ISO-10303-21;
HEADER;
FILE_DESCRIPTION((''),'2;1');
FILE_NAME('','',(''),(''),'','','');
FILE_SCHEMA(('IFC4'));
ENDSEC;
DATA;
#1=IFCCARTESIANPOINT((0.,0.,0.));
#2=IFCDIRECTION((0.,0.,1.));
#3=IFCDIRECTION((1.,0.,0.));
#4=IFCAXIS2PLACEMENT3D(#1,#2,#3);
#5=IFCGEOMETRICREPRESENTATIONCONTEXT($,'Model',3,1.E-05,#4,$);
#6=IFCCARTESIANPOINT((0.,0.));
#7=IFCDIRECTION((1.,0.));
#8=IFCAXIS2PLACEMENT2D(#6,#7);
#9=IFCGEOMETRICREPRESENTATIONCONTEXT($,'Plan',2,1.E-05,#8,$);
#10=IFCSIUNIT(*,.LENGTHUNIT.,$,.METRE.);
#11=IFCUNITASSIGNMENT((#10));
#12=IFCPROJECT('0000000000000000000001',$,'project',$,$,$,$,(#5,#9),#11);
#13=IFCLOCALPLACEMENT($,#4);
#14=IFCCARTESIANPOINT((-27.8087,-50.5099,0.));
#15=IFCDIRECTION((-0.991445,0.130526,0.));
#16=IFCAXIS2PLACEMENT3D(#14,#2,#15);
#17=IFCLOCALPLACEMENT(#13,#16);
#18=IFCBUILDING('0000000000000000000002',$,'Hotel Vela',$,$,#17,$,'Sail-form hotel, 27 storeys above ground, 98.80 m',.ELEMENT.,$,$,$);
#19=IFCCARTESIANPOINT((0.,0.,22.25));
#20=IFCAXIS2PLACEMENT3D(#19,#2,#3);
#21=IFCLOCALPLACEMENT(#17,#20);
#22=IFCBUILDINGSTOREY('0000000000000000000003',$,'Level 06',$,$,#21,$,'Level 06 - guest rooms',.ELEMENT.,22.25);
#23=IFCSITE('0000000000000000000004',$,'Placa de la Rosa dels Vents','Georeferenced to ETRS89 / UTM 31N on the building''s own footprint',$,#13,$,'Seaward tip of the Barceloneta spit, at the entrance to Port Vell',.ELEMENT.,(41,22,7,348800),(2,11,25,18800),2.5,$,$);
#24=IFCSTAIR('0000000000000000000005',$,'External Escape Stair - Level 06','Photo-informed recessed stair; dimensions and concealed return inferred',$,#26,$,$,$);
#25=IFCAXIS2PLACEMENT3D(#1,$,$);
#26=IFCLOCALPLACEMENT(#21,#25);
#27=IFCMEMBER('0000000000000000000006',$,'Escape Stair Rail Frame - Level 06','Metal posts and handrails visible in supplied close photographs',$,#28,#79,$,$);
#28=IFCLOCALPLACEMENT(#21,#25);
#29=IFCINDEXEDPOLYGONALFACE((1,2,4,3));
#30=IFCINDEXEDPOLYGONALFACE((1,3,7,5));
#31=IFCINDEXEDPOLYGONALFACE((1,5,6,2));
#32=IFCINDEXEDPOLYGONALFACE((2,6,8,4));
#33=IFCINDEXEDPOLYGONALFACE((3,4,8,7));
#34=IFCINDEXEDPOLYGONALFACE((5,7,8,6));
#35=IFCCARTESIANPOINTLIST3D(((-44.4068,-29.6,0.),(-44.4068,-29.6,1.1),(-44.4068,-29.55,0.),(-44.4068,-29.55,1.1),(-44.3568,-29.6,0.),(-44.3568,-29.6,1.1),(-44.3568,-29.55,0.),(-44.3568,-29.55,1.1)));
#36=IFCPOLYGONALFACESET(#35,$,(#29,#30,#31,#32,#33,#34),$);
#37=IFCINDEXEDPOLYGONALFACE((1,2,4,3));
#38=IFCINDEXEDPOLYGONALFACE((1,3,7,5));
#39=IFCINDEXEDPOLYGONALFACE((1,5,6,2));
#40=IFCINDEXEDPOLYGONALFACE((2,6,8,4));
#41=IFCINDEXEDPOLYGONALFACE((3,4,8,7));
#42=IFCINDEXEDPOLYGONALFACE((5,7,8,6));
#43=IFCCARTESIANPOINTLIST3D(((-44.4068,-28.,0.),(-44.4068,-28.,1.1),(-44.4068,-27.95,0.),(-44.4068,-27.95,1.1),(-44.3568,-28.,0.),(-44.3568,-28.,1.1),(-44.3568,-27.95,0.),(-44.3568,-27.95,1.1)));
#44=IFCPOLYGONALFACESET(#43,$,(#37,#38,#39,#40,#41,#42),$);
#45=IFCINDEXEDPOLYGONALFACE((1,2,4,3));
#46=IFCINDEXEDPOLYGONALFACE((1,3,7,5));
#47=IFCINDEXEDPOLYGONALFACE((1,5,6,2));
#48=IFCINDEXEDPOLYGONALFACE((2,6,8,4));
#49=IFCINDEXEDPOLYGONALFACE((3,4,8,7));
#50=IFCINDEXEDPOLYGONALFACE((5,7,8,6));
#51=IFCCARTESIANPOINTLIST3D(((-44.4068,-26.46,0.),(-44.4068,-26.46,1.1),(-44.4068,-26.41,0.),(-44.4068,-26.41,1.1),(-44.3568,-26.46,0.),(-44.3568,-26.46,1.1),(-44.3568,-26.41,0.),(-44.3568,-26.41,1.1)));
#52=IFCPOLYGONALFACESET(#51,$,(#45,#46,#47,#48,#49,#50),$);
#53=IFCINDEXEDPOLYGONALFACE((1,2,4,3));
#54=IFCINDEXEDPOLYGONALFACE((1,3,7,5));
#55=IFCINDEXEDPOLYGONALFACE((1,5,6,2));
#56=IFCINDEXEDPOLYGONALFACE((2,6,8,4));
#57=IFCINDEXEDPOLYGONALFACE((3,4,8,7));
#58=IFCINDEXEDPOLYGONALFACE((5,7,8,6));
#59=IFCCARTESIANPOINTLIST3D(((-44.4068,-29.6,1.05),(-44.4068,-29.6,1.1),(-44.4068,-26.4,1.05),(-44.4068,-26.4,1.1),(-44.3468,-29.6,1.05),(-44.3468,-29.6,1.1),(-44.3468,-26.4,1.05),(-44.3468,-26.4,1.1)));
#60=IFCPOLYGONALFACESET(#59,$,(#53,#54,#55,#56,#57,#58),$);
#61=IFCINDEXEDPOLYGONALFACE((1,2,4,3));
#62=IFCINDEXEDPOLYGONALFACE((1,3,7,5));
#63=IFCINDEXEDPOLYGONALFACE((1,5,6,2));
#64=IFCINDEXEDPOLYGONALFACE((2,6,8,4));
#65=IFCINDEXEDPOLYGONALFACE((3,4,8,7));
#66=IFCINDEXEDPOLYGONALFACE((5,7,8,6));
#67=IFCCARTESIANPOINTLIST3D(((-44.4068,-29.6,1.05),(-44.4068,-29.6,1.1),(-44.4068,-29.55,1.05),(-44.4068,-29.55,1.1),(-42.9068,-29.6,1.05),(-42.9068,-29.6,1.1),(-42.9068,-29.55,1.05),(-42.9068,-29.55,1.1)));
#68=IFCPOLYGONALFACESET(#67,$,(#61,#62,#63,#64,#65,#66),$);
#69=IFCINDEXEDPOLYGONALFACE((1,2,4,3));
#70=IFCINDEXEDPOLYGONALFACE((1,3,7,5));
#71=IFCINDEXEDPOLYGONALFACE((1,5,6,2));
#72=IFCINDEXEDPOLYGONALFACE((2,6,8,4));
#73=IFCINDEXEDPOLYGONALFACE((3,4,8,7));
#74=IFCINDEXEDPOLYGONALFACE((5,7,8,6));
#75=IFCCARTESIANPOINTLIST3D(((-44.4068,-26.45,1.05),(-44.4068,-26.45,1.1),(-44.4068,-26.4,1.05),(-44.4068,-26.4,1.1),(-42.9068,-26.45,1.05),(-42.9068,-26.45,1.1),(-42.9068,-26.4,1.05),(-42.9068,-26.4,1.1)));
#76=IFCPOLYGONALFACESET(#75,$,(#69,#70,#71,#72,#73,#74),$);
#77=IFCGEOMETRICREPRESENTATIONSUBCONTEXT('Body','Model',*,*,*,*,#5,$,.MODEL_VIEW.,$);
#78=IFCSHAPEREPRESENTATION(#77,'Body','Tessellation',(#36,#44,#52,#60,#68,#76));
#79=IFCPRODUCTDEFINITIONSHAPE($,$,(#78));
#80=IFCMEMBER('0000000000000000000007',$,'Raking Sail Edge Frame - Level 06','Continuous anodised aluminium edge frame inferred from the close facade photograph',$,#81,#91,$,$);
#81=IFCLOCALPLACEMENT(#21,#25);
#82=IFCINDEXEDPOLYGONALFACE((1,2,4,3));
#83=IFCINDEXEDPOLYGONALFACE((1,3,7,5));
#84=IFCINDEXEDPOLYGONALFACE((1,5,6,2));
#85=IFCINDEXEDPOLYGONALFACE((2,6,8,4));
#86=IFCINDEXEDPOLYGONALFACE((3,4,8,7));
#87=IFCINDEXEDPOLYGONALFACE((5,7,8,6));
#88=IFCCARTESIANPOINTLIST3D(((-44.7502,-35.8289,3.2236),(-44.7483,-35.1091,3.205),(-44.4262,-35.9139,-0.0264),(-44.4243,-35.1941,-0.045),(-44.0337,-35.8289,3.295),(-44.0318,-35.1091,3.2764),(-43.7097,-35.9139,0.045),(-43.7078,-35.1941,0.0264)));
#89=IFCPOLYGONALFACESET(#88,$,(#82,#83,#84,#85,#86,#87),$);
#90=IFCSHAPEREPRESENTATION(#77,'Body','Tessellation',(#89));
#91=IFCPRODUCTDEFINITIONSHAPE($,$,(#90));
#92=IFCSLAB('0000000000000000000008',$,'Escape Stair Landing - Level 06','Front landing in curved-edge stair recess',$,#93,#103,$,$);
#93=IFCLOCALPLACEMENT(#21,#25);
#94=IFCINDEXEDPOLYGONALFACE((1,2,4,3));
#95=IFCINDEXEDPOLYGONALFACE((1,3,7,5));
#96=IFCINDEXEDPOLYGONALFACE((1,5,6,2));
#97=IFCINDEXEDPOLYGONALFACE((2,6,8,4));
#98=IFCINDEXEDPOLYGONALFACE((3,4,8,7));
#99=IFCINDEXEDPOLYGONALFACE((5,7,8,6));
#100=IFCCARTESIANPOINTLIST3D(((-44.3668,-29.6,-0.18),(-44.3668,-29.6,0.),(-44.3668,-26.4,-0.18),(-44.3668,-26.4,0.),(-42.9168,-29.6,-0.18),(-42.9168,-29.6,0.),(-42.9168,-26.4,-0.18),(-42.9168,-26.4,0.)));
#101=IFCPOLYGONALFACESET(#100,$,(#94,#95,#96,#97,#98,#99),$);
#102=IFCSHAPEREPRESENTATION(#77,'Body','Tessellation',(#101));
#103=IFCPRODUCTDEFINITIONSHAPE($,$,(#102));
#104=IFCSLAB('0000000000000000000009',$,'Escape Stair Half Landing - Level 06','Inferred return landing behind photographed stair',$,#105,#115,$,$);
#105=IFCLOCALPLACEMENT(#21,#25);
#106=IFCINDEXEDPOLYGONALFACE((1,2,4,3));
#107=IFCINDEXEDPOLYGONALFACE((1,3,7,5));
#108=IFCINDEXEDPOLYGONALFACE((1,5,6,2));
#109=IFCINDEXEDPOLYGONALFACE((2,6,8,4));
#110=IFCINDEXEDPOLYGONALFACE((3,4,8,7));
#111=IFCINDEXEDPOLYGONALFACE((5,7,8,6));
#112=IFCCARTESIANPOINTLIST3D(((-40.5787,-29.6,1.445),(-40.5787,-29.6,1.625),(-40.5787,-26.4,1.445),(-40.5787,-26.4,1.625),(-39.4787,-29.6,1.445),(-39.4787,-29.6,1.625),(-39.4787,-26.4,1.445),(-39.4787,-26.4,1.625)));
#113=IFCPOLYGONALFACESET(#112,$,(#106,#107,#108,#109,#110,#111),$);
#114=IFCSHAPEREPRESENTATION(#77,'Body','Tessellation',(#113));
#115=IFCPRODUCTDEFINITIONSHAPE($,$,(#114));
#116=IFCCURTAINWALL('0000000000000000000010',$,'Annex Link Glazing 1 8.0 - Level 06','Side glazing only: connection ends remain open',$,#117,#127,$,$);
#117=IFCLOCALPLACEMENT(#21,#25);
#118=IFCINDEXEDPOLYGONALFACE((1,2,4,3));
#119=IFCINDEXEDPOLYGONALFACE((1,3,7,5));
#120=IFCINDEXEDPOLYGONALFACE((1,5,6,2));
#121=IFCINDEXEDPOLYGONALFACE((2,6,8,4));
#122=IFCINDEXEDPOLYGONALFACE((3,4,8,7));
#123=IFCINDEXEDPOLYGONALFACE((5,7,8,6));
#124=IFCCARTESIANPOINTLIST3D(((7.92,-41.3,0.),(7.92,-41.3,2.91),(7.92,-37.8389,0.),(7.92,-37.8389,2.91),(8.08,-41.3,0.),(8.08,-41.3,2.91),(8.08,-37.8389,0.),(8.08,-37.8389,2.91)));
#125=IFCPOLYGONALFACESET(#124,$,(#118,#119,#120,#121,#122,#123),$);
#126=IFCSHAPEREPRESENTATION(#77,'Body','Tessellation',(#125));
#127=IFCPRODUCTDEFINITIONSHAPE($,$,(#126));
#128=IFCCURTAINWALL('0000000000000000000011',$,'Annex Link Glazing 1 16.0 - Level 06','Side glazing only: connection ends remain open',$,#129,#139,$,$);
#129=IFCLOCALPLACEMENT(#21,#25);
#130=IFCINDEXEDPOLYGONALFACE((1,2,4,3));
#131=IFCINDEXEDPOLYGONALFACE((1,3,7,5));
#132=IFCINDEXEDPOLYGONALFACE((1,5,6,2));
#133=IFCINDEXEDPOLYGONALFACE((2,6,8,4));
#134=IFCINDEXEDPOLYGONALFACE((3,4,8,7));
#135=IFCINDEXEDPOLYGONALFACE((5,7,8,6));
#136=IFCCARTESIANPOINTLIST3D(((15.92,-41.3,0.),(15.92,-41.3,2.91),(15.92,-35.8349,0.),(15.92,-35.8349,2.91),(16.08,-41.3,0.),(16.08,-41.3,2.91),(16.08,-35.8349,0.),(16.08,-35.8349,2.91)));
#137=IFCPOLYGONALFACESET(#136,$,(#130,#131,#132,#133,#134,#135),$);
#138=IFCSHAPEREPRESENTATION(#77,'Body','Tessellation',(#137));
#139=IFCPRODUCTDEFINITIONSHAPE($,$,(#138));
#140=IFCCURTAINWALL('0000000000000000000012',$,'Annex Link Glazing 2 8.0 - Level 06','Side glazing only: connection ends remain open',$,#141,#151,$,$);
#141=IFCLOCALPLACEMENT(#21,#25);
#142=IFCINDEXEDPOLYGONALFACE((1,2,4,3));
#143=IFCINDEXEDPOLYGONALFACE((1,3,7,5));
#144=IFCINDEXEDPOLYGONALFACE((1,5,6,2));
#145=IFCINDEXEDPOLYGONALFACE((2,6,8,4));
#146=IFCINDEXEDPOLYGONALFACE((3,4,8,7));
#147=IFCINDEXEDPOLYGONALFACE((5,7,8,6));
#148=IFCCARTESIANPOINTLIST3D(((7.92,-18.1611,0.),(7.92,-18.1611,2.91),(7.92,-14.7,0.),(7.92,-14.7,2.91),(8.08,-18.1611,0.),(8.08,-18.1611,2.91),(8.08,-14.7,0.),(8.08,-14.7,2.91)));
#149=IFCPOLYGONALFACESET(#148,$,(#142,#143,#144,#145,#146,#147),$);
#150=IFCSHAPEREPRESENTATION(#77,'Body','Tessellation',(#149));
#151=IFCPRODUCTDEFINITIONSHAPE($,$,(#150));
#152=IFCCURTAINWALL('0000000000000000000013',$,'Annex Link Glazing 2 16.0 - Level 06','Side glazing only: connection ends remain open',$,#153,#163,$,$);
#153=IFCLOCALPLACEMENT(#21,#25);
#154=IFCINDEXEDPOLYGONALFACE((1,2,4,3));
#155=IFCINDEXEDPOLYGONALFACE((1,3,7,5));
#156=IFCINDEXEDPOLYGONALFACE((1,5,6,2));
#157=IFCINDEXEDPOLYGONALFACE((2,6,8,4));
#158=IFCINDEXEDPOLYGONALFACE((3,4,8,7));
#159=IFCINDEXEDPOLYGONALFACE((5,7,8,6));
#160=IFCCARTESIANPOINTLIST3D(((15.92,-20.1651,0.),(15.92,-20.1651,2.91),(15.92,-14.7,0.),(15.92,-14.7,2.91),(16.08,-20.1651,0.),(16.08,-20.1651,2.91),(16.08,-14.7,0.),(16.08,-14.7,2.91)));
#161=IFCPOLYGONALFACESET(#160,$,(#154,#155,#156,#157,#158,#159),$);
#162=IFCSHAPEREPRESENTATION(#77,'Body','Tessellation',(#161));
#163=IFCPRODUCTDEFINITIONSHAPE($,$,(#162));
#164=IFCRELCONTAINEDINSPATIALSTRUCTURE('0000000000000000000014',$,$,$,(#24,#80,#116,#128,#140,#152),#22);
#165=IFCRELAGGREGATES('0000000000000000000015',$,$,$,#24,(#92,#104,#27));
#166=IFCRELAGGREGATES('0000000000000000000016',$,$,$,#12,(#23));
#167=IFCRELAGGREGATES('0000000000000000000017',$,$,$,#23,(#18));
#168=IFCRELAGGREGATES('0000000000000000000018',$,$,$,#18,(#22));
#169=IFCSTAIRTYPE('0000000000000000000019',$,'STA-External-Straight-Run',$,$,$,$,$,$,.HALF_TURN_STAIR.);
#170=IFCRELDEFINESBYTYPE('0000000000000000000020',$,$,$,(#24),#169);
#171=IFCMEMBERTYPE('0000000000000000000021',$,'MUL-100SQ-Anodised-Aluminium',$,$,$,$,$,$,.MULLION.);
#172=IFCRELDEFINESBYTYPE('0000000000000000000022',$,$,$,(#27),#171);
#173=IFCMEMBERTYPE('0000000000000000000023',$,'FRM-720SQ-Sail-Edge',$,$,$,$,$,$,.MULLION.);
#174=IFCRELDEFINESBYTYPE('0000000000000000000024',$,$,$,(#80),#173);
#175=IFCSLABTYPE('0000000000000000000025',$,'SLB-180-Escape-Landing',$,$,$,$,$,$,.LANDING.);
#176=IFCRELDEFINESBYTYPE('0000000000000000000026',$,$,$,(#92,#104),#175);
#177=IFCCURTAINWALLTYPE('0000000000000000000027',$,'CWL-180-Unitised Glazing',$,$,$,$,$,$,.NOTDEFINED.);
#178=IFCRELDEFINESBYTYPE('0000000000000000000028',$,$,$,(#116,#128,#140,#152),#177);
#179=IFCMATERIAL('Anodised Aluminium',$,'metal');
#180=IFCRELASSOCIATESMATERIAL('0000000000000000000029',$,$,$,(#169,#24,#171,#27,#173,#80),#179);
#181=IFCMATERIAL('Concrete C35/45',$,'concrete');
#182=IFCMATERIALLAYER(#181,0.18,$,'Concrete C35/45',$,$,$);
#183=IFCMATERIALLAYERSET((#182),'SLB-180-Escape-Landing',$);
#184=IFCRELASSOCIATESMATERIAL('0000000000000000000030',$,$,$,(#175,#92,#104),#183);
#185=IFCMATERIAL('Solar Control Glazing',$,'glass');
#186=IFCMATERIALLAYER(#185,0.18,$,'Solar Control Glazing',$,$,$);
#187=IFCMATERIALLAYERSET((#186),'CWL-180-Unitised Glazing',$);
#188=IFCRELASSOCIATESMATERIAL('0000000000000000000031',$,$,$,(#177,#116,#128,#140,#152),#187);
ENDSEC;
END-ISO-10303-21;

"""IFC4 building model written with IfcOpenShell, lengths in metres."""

from ifc_helpers import new_model, si_unit, frame, origin_with_axes, origin_2d_with_axis, place, context, subcontext, project, spatial, line, indexed_curve, rectangle, outline, extrude, material, layer, layer_set, layer_usage, material_profile, profile_set, profile_usage, type_object, element, aggregate, save


model = new_model("IFC4")

# Units and contexts
model_context = context("Model", 3, precision=1e-05, world=origin_with_axes())
plan_context = context("Plan", 2, precision=1e-05, world=origin_2d_with_axis())
body_context = subcontext(model_context, "Body", "Model", "MODEL_VIEW")
ifc_project = project(units=[si_unit("LENGTHUNIT", "METRE")], contexts=[model_context, plan_context])

# Site, building, storey
site_placement = place(None, origin_with_axes())
site = spatial("IfcSite", under=ifc_project, at=site_placement, Name="Placa de la Rosa dels Vents", Description="Georeferenced to ETRS89 / UTM 31N on the building's own footprint", LongName="Seaward tip of the Barceloneta spit, at the entrance to Port Vell", CompositionType="ELEMENT", RefLatitude=(41, 22, 7, 348800), RefLongitude=(2, 11, 25, 18800), RefElevation=2.5)
building_placement = place(site_placement, frame((-27.8087, -50.5099, 0.0), z_axis=(0.0, 0.0, 1.0), x_axis=(-0.991445, 0.130526, 0.0)))
building = spatial("IfcBuilding", under=site, at=building_placement, Name="Hotel Vela", LongName="Sail-form hotel, 27 storeys above ground, 98.80 m", CompositionType="ELEMENT")
storey_placement = place(building_placement, frame((0.0, 0.0, 22.25), z_axis=(0.0, 0.0, 1.0), x_axis=(1.0, 0.0, 0.0)))
storey = spatial("IfcBuildingStorey", under=building, at=storey_placement, Name="Level 06", LongName="Level 06 - guest rooms", CompositionType="ELEMENT", Elevation=22.25)

# Stair, member
ifc_material_1 = material(Name="Anodised Aluminium", Category="metal")
stair_type = type_object("IfcStairType", Name="STA-External-Straight-Run", PredefinedType="HALF_TURN_STAIR", material=ifc_material_1)
stair_placement = place(storey_placement, frame((0.0, 0.0, -22.25), z_axis=(0.0, 0.0, 1.0), x_axis=(1.0, 0.0, 0.0)))
stair = element("IfcStair", 1, at=stair_placement, inside=storey, type_object=stair_type, material=ifc_material_1, Name="External Escape Stair - Level 06", Description="Photo-informed recessed stair; dimensions and concealed return inferred")
ifc_material_profile_1 = material_profile(ifc_material_1, rectangle(XDim=0.1, YDim=0.1))
ifc_profile_set_1 = profile_set([ifc_material_profile_1], Name="MUL-100SQ-Anodised-Aluminium")
ifc_profile_usage_1 = profile_usage(ifc_profile_set_1)
member_type_1 = type_object("IfcMemberType", Name="MUL-100SQ-Anodised-Aluminium", PredefinedType="MULLION", material=ifc_profile_set_1)
member_1_placement = place(stair_placement, origin_with_axes())
member_1 = element("IfcMember", 2, at=member_1_placement, type_object=member_type_1, material=ifc_profile_usage_1, Name="Escape Stair Rail Frame - Level 06", Description="Metal posts and handrails visible in supplied close photographs", context=body_context, shape_type="SweptSolid", body=[
    extrude(outline(indexed_curve([(0.0, 0.0), (0.05, 0.0), (0.05, 0.05), (0.0, 0.05)], segments=[line(1, 2, 3, 4, 1)])), frame((-44.4068, -29.6, 22.25), z_axis=(0.0, 0.0, 1.0), x_axis=(1.0, 0.0, 0.0)), (0.0, 0.0, 1.0), 1.1),
    extrude(outline(indexed_curve([(0.0, 0.0), (0.05, 0.0), (0.05, 0.05), (0.0, 0.05)], segments=[line(1, 2, 3, 4, 1)])), frame((-44.4068, -28.0, 22.25), z_axis=(0.0, 0.0, 1.0), x_axis=(1.0, 0.0, 0.0)), (0.0, 0.0, 1.0), 1.1),
    extrude(outline(indexed_curve([(0.0, 0.0), (0.05, 0.0), (0.05, 0.05), (0.0, 0.05)], segments=[line(1, 2, 3, 4, 1)])), frame((-44.4068, -26.46, 22.25), z_axis=(0.0, 0.0, 1.0), x_axis=(1.0, 0.0, 0.0)), (0.0, 0.0, 1.0), 1.1),
    extrude(outline(indexed_curve([(0.0, 0.0), (0.06, 0.0), (0.06, 3.2), (0.0, 3.2)], segments=[line(1, 2, 3, 4, 1)])), frame((-44.4068, -29.6, 23.3), z_axis=(0.0, 0.0, 1.0), x_axis=(1.0, 0.0, 0.0)), (0.0, 0.0, 1.0), 0.05),
    extrude(outline(indexed_curve([(0.0, 0.0), (1.5, 0.0), (1.5, 0.05), (0.0, 0.05)], segments=[line(1, 2, 3, 4, 1)])), frame((-44.4068, -29.6, 23.3), z_axis=(0.0, 0.0, 1.0), x_axis=(1.0, 0.0, 0.0)), (0.0, 0.0, 1.0), 0.05),
    extrude(outline(indexed_curve([(0.0, 0.0), (1.5, 0.0), (1.5, 0.05), (0.0, 0.05)], segments=[line(1, 2, 3, 4, 1)])), frame((-44.4068, -26.45, 23.3), z_axis=(0.0, 0.0, 1.0), x_axis=(1.0, 0.0, 0.0)), (0.0, 0.0, 1.0), 0.05),
])

# Member
ifc_material_profile_2 = material_profile(ifc_material_1, rectangle(XDim=0.72, YDim=0.72))
ifc_profile_set_2 = profile_set([ifc_material_profile_2], Name="FRM-720SQ-Sail-Edge")
ifc_profile_usage_2 = profile_usage(ifc_profile_set_2)
member_type_2 = type_object("IfcMemberType", Name="FRM-720SQ-Sail-Edge", PredefinedType="MULLION", material=ifc_profile_set_2)
member_2_placement = place(storey_placement, frame((-44.067, -35.554, 0.0), z_axis=(-0.099167, 0.026016, 0.994731), x_axis=(0.995067, 0.0, 0.099201)))
element("IfcMember", 3, at=member_2_placement, inside=storey, type_object=member_type_2, material=ifc_profile_usage_2, Name="Raking Sail Edge Frame - Level 06", Description="Continuous anodised aluminium edge frame inferred from the close facade photograph", context=body_context, shape_type="SweptSolid", body=[
    extrude(outline(indexed_curve([(-0.36, -0.36), (0.36, -0.36), (0.36, 0.36), (-0.36, 0.36)], segments=[line(1, 2, 3, 4, 1)])), origin_with_axes(), (0.0, 0.0, 1.0), 3.2672),
])

# Slabs
ifc_material_2 = material(Name="Concrete C35/45", Category="concrete")
ifc_layer_1 = layer(ifc_material_2, 0.18, Name="Concrete C35/45")
ifc_layer_set_1 = layer_set([ifc_layer_1], Name="SLB-180-Escape-Landing")
ifc_layer_usage_1 = layer_usage(ifc_layer_set_1, "AXIS3", "POSITIVE", 0.0)
slab_type = type_object("IfcSlabType", Name="SLB-180-Escape-Landing", PredefinedType="LANDING", material=ifc_layer_set_1)
slab_1_placement = place(stair_placement, frame((-44.3668, -29.6, 22.07), z_axis=(0.0, 0.0, 1.0), x_axis=(1.0, 0.0, 0.0)))
slab_1 = element("IfcSlab", 4, at=slab_1_placement, type_object=slab_type, material=ifc_layer_usage_1, Name="Escape Stair Landing - Level 06", Description="Front landing in curved-edge stair recess", context=body_context, shape_type="SweptSolid", body=[
    extrude(outline(indexed_curve([(0.0, 0.0), (1.45, 0.0), (1.45, 3.2), (0.0, 3.2)], segments=[line(1, 2, 3, 4, 1)])), origin_with_axes(), (0.0, 0.0, 1.0), 0.18),
])
ifc_layer_usage_2 = layer_usage(ifc_layer_set_1, "AXIS3", "POSITIVE", 0.0)
slab_2_placement = place(stair_placement, frame((-40.5787, -29.6, 23.695), z_axis=(0.0, 0.0, 1.0), x_axis=(1.0, 0.0, 0.0)))
slab_2 = element("IfcSlab", 5, at=slab_2_placement, type_object=slab_type, material=ifc_layer_usage_2, Name="Escape Stair Half Landing - Level 06", Description="Inferred return landing behind photographed stair", context=body_context, shape_type="SweptSolid", body=[
    extrude(outline(indexed_curve([(0.0, 0.0), (1.1, 0.0), (1.1, 3.2), (0.0, 3.2)], segments=[line(1, 2, 3, 4, 1)])), origin_with_axes(), (0.0, 0.0, 1.0), 0.18),
])

# Curtain walls
ifc_material_3 = material(Name="Solar Control Glazing", Category="glass")
ifc_layer_2 = layer(ifc_material_3, 0.18, Name="Solar Control Glazing")
ifc_layer_set_2 = layer_set([ifc_layer_2], Name="CWL-180-Unitised Glazing")
ifc_layer_usage_3 = layer_usage(ifc_layer_set_2, "AXIS2", "POSITIVE", 0.0)
curtain_wall_type = type_object("IfcCurtainWallType", Name="CWL-180-Unitised Glazing", PredefinedType="NOTDEFINED", material=ifc_layer_set_2)
curtain_wall_1_placement = place(storey_placement, frame((7.92, -41.3, 0.0), z_axis=(0.0, 0.0, 1.0), x_axis=(1.0, 0.0, 0.0)))
element("IfcCurtainWall", 6, at=curtain_wall_1_placement, inside=storey, type_object=curtain_wall_type, material=ifc_layer_usage_3, Name="Annex Link Glazing 1 8.0 - Level 06", Description="Side glazing only: connection ends remain open", context=body_context, shape_type="SweptSolid", body=[
    extrude(outline(indexed_curve([(0.0, 0.0), (0.16, 0.0), (0.16, 3.4611), (0.0, 3.4611)], segments=[line(1, 2, 3, 4, 1)])), origin_with_axes(), (0.0, 0.0, 1.0), 2.91),
])
ifc_layer_usage_4 = layer_usage(ifc_layer_set_2, "AXIS2", "POSITIVE", 0.0)
curtain_wall_2_placement = place(storey_placement, frame((15.92, -41.3, 0.0), z_axis=(0.0, 0.0, 1.0), x_axis=(1.0, 0.0, 0.0)))
element("IfcCurtainWall", 7, at=curtain_wall_2_placement, inside=storey, type_object=curtain_wall_type, material=ifc_layer_usage_4, Name="Annex Link Glazing 1 16.0 - Level 06", Description="Side glazing only: connection ends remain open", context=body_context, shape_type="SweptSolid", body=[
    extrude(outline(indexed_curve([(0.0, 0.0), (0.16, 0.0), (0.16, 5.4651), (0.0, 5.4651)], segments=[line(1, 2, 3, 4, 1)])), origin_with_axes(), (0.0, 0.0, 1.0), 2.91),
])
ifc_layer_usage_5 = layer_usage(ifc_layer_set_2, "AXIS2", "POSITIVE", 0.0)
curtain_wall_3_placement = place(storey_placement, frame((7.92, -18.1611, 0.0), z_axis=(0.0, 0.0, 1.0), x_axis=(1.0, 0.0, 0.0)))
element("IfcCurtainWall", 8, at=curtain_wall_3_placement, inside=storey, type_object=curtain_wall_type, material=ifc_layer_usage_5, Name="Annex Link Glazing 2 8.0 - Level 06", Description="Side glazing only: connection ends remain open", context=body_context, shape_type="SweptSolid", body=[
    extrude(outline(indexed_curve([(0.0, 0.0), (0.16, 0.0), (0.16, 3.4611), (0.0, 3.4611)], segments=[line(1, 2, 3, 4, 1)])), origin_with_axes(), (0.0, 0.0, 1.0), 2.91),
])
ifc_layer_usage_6 = layer_usage(ifc_layer_set_2, "AXIS2", "POSITIVE", 0.0)
curtain_wall_4_placement = place(storey_placement, frame((15.92, -20.1651, 0.0), z_axis=(0.0, 0.0, 1.0), x_axis=(1.0, 0.0, 0.0)))
element("IfcCurtainWall", 9, at=curtain_wall_4_placement, inside=storey, type_object=curtain_wall_type, material=ifc_layer_usage_6, Name="Annex Link Glazing 2 16.0 - Level 06", Description="Side glazing only: connection ends remain open", context=body_context, shape_type="SweptSolid", body=[
    extrude(outline(indexed_curve([(0.0, 0.0), (0.16, 0.0), (0.16, 5.4651), (0.0, 5.4651)], segments=[line(1, 2, 3, 4, 1)])), origin_with_axes(), (0.0, 0.0, 1.0), 2.91),
])

aggregate(stair, [slab_1, slab_2, member_1])

save(model, "model.ifc")
